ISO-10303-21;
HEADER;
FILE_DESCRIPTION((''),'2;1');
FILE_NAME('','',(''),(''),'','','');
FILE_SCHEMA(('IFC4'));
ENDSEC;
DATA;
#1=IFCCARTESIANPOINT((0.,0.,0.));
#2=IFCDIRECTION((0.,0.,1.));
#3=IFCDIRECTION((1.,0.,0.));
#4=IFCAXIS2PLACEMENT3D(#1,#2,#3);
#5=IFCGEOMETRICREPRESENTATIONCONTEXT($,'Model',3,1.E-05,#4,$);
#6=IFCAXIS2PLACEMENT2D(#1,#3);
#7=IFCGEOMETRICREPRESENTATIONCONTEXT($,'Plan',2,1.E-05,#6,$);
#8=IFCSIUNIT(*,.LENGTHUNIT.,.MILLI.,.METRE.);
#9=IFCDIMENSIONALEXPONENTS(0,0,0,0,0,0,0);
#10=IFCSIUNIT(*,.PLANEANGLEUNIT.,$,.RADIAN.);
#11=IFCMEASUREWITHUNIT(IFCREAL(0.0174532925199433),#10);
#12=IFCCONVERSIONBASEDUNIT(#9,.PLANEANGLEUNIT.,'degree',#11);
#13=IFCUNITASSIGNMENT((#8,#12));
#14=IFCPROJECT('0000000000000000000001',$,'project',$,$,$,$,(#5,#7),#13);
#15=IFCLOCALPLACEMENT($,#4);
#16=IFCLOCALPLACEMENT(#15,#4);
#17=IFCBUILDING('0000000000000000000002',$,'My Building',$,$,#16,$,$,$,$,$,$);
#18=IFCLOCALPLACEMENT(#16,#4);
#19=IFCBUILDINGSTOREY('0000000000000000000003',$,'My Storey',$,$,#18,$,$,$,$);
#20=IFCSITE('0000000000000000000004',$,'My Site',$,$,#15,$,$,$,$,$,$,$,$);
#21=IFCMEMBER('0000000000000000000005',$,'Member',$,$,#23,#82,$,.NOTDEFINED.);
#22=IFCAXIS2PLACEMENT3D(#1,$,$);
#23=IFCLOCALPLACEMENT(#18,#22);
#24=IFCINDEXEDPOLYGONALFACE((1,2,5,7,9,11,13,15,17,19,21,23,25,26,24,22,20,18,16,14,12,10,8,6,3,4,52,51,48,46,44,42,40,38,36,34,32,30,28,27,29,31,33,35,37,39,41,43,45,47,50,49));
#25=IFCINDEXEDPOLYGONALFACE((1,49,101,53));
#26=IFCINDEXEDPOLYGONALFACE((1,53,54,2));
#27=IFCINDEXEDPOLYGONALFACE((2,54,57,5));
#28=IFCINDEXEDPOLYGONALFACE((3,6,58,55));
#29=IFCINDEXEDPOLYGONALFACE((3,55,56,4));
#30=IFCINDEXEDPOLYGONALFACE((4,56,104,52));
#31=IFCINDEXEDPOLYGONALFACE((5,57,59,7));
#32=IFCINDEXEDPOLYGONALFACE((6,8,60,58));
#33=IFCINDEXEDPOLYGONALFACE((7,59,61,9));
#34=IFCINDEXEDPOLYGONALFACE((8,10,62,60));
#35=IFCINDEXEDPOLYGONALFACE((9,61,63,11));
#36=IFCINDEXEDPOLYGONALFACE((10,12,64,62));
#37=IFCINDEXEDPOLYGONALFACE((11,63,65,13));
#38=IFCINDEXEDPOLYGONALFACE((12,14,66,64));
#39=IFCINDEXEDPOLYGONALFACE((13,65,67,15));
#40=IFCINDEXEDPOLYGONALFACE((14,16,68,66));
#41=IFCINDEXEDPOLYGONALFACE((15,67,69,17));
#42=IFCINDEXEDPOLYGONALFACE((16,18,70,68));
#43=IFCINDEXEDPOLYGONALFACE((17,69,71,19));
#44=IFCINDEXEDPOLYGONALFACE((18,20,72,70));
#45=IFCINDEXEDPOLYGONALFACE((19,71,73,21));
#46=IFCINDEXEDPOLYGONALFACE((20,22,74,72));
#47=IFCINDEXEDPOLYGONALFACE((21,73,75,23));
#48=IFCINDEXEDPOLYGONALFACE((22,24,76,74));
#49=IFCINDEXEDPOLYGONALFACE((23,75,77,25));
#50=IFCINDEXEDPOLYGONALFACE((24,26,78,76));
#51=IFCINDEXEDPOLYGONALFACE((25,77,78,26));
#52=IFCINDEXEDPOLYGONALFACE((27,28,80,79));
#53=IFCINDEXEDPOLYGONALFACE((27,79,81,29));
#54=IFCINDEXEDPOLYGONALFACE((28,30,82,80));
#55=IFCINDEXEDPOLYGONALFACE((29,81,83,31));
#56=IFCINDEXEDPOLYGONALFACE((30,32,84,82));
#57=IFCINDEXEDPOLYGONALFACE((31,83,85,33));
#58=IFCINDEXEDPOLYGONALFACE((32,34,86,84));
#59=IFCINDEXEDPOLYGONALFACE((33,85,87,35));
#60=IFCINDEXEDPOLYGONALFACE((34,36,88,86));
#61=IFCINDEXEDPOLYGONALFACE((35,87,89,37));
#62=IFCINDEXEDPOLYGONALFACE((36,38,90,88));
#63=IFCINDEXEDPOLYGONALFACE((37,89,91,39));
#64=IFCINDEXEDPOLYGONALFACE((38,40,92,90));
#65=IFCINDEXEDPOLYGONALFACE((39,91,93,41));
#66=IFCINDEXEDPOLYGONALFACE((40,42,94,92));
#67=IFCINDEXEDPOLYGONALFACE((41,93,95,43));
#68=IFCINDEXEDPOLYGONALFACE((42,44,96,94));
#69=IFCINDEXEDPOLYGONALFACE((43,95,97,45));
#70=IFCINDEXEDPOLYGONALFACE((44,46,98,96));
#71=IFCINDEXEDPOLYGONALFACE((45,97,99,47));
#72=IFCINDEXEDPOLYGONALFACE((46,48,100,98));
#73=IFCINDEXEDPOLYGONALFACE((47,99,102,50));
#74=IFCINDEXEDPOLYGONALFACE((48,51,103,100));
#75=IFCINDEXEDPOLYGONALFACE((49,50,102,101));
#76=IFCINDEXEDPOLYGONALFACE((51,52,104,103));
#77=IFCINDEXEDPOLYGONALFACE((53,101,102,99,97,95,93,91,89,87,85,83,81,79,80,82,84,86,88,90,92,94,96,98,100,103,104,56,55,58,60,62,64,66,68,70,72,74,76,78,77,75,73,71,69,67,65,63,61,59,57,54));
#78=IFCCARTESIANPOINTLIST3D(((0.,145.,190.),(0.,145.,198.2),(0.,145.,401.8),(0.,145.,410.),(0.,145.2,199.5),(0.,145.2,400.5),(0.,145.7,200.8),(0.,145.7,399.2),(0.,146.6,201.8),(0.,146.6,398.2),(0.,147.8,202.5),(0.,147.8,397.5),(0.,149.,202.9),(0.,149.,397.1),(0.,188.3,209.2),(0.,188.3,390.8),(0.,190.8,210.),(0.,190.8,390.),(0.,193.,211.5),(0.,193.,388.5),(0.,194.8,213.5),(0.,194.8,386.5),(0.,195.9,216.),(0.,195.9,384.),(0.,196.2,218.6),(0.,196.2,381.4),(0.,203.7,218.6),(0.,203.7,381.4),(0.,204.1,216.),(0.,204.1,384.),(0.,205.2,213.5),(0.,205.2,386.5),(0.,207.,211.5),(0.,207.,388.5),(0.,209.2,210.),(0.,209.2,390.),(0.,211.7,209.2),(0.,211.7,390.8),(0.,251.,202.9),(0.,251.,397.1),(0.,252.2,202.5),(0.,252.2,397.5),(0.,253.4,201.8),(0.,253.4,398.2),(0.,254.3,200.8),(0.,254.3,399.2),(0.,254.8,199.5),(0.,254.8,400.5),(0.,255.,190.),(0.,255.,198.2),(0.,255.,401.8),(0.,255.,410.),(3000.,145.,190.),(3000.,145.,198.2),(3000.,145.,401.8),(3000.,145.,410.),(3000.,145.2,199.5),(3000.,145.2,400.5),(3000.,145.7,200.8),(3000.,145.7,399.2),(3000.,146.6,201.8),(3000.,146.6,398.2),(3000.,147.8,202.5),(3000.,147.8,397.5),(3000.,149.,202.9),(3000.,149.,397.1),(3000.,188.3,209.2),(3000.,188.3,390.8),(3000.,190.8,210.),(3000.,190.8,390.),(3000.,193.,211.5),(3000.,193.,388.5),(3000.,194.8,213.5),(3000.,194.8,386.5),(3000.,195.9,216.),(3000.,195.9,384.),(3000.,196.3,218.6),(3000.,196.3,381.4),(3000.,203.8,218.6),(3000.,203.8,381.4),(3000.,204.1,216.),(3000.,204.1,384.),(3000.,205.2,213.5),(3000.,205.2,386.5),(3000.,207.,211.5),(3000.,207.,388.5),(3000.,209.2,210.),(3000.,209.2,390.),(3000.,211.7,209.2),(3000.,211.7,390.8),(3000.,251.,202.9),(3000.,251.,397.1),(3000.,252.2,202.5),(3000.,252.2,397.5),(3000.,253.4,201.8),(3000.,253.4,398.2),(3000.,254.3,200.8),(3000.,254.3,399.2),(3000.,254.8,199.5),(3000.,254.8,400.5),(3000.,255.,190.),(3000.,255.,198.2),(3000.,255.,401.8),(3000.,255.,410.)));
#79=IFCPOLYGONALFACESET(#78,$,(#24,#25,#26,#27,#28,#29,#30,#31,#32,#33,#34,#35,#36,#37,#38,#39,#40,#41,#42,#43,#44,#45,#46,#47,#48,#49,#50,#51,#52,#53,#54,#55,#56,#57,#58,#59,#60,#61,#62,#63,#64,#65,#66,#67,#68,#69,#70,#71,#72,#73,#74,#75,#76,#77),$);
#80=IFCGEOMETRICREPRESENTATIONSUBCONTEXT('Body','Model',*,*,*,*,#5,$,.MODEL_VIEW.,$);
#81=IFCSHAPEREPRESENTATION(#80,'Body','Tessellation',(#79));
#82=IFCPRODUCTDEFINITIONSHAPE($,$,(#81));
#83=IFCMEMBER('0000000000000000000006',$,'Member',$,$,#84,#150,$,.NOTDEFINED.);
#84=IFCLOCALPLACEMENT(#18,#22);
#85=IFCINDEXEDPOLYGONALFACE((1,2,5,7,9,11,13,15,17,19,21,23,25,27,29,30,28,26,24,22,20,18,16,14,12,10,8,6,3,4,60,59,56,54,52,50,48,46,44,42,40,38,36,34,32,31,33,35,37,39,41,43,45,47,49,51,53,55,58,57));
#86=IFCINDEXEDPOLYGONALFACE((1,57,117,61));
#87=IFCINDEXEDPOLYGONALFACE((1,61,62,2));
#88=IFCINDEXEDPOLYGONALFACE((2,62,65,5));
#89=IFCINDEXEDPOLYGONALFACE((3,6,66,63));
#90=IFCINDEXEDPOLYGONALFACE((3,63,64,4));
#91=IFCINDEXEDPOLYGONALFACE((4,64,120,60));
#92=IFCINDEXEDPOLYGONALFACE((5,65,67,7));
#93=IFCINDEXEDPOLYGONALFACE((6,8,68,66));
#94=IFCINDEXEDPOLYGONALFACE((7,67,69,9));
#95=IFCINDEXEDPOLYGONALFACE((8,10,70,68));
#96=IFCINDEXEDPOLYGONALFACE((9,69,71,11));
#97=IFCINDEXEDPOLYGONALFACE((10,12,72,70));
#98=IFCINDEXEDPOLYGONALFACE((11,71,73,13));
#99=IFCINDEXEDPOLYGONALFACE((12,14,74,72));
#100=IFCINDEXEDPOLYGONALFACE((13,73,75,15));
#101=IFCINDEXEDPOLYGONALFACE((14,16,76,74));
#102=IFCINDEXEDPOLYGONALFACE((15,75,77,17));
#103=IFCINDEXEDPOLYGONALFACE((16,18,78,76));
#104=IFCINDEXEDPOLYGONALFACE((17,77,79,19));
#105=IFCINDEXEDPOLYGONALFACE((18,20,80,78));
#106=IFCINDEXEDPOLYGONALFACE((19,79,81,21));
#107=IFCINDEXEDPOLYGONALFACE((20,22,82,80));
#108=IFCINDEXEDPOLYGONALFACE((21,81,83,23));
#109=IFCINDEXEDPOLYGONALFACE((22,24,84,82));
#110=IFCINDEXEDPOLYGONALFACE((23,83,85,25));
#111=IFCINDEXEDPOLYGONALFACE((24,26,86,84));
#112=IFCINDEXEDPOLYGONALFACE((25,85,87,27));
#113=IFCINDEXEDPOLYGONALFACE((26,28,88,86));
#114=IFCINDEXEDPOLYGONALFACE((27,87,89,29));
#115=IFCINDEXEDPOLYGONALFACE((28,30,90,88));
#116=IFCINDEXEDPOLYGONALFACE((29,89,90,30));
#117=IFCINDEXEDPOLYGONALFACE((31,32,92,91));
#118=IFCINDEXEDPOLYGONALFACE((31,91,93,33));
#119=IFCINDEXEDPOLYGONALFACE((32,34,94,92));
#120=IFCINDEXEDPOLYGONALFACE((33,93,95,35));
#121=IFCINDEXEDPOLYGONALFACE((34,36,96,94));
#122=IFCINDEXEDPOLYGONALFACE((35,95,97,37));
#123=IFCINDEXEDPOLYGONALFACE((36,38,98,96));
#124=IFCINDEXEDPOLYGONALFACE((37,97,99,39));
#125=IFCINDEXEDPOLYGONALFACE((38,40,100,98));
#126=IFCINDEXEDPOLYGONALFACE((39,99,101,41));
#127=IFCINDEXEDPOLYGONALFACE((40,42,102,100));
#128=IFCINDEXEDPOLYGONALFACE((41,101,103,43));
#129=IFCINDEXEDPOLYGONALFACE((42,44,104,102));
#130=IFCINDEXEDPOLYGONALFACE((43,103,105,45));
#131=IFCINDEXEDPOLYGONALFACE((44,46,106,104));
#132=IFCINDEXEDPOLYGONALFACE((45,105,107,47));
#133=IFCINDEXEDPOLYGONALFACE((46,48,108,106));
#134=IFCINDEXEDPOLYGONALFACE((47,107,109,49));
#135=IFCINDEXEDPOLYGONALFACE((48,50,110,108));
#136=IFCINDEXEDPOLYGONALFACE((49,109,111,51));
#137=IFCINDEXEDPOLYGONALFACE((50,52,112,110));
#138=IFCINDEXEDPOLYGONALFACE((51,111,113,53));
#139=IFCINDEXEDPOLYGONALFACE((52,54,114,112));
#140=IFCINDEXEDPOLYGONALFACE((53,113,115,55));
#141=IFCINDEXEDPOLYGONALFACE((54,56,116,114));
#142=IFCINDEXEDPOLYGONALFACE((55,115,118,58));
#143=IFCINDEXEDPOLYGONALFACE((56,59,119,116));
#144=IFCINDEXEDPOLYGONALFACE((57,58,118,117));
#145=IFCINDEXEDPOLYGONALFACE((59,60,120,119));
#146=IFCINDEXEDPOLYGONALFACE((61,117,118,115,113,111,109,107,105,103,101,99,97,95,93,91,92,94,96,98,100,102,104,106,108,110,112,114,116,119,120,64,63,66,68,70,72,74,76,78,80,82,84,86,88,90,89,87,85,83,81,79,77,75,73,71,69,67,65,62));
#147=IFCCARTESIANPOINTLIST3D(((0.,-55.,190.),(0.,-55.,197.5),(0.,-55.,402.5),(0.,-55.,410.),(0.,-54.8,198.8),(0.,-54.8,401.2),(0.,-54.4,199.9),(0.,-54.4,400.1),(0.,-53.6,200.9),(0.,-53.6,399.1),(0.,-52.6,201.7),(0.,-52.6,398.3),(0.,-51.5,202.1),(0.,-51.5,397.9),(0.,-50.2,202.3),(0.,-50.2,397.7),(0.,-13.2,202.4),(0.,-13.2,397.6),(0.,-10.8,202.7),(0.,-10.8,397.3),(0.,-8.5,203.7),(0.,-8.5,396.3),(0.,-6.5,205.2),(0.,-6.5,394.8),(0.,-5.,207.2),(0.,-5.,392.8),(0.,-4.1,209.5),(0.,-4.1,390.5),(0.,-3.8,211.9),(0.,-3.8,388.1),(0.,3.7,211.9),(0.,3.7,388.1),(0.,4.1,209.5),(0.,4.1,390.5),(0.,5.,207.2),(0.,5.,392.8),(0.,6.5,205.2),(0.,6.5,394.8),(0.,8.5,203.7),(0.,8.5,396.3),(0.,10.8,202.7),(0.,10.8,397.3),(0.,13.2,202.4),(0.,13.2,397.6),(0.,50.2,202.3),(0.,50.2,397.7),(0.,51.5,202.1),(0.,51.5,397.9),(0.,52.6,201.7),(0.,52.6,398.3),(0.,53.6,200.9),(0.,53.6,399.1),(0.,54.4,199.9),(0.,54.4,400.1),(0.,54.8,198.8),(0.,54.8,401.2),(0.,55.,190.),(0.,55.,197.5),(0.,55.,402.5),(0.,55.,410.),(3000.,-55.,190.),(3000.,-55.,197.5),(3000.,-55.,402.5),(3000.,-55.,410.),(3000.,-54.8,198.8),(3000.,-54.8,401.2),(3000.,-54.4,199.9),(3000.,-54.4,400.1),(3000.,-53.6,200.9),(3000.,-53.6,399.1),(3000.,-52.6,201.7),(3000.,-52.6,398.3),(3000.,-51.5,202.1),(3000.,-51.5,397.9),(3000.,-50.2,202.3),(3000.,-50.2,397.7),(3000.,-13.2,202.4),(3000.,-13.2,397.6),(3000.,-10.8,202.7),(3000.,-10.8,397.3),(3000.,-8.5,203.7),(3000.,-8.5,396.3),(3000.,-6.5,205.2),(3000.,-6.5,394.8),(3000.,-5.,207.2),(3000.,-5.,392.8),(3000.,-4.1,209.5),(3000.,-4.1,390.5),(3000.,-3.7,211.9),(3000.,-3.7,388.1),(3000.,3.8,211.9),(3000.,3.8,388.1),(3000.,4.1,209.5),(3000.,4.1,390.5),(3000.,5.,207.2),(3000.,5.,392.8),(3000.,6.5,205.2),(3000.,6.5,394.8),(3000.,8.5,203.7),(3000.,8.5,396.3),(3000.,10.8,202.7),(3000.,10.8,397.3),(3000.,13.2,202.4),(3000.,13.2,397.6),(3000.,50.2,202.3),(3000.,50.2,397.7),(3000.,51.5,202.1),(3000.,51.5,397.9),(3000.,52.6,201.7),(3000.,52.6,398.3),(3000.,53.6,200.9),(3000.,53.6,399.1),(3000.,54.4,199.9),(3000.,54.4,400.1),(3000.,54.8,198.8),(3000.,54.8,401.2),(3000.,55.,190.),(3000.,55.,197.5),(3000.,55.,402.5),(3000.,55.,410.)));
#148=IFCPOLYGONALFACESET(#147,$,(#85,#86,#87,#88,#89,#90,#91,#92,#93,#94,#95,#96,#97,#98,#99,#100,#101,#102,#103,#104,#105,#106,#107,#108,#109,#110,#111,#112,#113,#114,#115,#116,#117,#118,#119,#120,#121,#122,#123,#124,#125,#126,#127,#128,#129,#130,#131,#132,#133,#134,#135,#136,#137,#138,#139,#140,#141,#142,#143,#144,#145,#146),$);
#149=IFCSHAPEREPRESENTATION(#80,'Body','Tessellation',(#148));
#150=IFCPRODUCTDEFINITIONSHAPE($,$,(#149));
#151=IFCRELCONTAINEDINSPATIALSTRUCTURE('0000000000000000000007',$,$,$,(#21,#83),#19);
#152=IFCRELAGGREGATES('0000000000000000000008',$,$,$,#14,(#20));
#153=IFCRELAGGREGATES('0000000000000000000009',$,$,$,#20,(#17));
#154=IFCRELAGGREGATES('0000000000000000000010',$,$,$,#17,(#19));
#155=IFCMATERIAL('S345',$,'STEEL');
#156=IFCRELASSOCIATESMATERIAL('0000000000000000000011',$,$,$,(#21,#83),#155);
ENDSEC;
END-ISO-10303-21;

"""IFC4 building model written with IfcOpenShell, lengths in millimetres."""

from ifc_helpers import new_model, entity, si_unit, converted_unit, frame, frame_2d, origin_with_axes, place, context, subcontext, project, spatial, i_section, extrude, material, material_profile, profile_set, profile_usage, element, save


model = new_model("IFC4")

# Units and contexts
model_context = context("Model", 3, precision=1e-05, world=origin_with_axes())
plan_context = context("Plan", 2, precision=1e-05, world=frame_2d((0.0, 0.0, 0.0), x_axis=(1.0, 0.0, 0.0)))
body_context = subcontext(model_context, "Body", "Model", "MODEL_VIEW")
ifc_project = project(units=[si_unit("LENGTHUNIT", "METRE", prefix="MILLI"), converted_unit("PLANEANGLEUNIT", "degree", entity("IfcReal", 0.0174532925199433), si_unit("PLANEANGLEUNIT", "RADIAN"), dimensions=[0, 0, 0, 0, 0, 0, 0])], contexts=[model_context, plan_context])

# Site, building, storey
site_placement = place(None, origin_with_axes())
site = spatial("IfcSite", under=ifc_project, at=site_placement, Name="My Site")
building_placement = place(site_placement, origin_with_axes())
building = spatial("IfcBuilding", under=site, at=building_placement, Name="My Building")
storey_placement = place(building_placement, origin_with_axes())
storey = spatial("IfcBuildingStorey", under=building, at=storey_placement, Name="My Storey")

# Members
ifc_material = material(Name="S345", Category="STEEL")
ifc_material_profile_1 = material_profile(ifc_material, i_section(OverallWidth=110.0, OverallDepth=220.0, WebThickness=7.5, FlangeThickness=12.3, FilletRadius=9.5, FlangeEdgeRadius=4.8, FlangeSlope=9.09))
ifc_profile_set_1 = profile_set([ifc_material_profile_1])
ifc_profile_usage_1 = profile_usage(ifc_profile_set_1)
member_1_placement = place(storey_placement, frame((0.0, 200.0, 0.0), z_axis=(1.0, 0.0, 0.0), x_axis=(0.0, 1.0, 0.0)))
element("IfcMember", 1, at=member_1_placement, inside=storey, material=ifc_profile_usage_1, Name="Member", PredefinedType="NOTDEFINED", context=body_context, shape_type="SweptSolid", body=[
    extrude(i_section(OverallWidth=110.0, OverallDepth=220.0, WebThickness=7.5, FlangeThickness=12.3, FilletRadius=9.5, FlangeEdgeRadius=4.8, FlangeSlope=9.09), frame((0.0, 300.0, 0.0), z_axis=(0.0, 0.0, 1.0), x_axis=(1.0, 0.0, 0.0)), (0.0, 0.0, 1.0), 3000.0),
])
ifc_material_profile_2 = material_profile(ifc_material, i_section(OverallWidth=110.0, OverallDepth=220.0, WebThickness=7.5, FlangeThickness=12.3, FilletRadius=9.5, FlangeEdgeRadius=4.8, FlangeSlope=0.158655))
ifc_profile_set_2 = profile_set([ifc_material_profile_2])
ifc_profile_usage_2 = profile_usage(ifc_profile_set_2)
member_2_placement = place(storey_placement, frame((0.0, 0.0, 0.0), z_axis=(1.0, 0.0, 0.0), x_axis=(0.0, 1.0, 0.0)))
element("IfcMember", 2, at=member_2_placement, inside=storey, material=ifc_profile_usage_2, Name="Member", PredefinedType="NOTDEFINED", context=body_context, shape_type="SweptSolid", body=[
    extrude(i_section(OverallWidth=110.0, OverallDepth=220.0, WebThickness=7.5, FlangeThickness=12.3, FilletRadius=9.5, FlangeEdgeRadius=4.8, FlangeSlope=0.158655), frame((0.0, 300.0, 0.0), z_axis=(0.0, 0.0, 1.0), x_axis=(1.0, 0.0, 0.0)), (0.0, 0.0, 1.0), 3000.0),
])

save(model, "model.ifc")
